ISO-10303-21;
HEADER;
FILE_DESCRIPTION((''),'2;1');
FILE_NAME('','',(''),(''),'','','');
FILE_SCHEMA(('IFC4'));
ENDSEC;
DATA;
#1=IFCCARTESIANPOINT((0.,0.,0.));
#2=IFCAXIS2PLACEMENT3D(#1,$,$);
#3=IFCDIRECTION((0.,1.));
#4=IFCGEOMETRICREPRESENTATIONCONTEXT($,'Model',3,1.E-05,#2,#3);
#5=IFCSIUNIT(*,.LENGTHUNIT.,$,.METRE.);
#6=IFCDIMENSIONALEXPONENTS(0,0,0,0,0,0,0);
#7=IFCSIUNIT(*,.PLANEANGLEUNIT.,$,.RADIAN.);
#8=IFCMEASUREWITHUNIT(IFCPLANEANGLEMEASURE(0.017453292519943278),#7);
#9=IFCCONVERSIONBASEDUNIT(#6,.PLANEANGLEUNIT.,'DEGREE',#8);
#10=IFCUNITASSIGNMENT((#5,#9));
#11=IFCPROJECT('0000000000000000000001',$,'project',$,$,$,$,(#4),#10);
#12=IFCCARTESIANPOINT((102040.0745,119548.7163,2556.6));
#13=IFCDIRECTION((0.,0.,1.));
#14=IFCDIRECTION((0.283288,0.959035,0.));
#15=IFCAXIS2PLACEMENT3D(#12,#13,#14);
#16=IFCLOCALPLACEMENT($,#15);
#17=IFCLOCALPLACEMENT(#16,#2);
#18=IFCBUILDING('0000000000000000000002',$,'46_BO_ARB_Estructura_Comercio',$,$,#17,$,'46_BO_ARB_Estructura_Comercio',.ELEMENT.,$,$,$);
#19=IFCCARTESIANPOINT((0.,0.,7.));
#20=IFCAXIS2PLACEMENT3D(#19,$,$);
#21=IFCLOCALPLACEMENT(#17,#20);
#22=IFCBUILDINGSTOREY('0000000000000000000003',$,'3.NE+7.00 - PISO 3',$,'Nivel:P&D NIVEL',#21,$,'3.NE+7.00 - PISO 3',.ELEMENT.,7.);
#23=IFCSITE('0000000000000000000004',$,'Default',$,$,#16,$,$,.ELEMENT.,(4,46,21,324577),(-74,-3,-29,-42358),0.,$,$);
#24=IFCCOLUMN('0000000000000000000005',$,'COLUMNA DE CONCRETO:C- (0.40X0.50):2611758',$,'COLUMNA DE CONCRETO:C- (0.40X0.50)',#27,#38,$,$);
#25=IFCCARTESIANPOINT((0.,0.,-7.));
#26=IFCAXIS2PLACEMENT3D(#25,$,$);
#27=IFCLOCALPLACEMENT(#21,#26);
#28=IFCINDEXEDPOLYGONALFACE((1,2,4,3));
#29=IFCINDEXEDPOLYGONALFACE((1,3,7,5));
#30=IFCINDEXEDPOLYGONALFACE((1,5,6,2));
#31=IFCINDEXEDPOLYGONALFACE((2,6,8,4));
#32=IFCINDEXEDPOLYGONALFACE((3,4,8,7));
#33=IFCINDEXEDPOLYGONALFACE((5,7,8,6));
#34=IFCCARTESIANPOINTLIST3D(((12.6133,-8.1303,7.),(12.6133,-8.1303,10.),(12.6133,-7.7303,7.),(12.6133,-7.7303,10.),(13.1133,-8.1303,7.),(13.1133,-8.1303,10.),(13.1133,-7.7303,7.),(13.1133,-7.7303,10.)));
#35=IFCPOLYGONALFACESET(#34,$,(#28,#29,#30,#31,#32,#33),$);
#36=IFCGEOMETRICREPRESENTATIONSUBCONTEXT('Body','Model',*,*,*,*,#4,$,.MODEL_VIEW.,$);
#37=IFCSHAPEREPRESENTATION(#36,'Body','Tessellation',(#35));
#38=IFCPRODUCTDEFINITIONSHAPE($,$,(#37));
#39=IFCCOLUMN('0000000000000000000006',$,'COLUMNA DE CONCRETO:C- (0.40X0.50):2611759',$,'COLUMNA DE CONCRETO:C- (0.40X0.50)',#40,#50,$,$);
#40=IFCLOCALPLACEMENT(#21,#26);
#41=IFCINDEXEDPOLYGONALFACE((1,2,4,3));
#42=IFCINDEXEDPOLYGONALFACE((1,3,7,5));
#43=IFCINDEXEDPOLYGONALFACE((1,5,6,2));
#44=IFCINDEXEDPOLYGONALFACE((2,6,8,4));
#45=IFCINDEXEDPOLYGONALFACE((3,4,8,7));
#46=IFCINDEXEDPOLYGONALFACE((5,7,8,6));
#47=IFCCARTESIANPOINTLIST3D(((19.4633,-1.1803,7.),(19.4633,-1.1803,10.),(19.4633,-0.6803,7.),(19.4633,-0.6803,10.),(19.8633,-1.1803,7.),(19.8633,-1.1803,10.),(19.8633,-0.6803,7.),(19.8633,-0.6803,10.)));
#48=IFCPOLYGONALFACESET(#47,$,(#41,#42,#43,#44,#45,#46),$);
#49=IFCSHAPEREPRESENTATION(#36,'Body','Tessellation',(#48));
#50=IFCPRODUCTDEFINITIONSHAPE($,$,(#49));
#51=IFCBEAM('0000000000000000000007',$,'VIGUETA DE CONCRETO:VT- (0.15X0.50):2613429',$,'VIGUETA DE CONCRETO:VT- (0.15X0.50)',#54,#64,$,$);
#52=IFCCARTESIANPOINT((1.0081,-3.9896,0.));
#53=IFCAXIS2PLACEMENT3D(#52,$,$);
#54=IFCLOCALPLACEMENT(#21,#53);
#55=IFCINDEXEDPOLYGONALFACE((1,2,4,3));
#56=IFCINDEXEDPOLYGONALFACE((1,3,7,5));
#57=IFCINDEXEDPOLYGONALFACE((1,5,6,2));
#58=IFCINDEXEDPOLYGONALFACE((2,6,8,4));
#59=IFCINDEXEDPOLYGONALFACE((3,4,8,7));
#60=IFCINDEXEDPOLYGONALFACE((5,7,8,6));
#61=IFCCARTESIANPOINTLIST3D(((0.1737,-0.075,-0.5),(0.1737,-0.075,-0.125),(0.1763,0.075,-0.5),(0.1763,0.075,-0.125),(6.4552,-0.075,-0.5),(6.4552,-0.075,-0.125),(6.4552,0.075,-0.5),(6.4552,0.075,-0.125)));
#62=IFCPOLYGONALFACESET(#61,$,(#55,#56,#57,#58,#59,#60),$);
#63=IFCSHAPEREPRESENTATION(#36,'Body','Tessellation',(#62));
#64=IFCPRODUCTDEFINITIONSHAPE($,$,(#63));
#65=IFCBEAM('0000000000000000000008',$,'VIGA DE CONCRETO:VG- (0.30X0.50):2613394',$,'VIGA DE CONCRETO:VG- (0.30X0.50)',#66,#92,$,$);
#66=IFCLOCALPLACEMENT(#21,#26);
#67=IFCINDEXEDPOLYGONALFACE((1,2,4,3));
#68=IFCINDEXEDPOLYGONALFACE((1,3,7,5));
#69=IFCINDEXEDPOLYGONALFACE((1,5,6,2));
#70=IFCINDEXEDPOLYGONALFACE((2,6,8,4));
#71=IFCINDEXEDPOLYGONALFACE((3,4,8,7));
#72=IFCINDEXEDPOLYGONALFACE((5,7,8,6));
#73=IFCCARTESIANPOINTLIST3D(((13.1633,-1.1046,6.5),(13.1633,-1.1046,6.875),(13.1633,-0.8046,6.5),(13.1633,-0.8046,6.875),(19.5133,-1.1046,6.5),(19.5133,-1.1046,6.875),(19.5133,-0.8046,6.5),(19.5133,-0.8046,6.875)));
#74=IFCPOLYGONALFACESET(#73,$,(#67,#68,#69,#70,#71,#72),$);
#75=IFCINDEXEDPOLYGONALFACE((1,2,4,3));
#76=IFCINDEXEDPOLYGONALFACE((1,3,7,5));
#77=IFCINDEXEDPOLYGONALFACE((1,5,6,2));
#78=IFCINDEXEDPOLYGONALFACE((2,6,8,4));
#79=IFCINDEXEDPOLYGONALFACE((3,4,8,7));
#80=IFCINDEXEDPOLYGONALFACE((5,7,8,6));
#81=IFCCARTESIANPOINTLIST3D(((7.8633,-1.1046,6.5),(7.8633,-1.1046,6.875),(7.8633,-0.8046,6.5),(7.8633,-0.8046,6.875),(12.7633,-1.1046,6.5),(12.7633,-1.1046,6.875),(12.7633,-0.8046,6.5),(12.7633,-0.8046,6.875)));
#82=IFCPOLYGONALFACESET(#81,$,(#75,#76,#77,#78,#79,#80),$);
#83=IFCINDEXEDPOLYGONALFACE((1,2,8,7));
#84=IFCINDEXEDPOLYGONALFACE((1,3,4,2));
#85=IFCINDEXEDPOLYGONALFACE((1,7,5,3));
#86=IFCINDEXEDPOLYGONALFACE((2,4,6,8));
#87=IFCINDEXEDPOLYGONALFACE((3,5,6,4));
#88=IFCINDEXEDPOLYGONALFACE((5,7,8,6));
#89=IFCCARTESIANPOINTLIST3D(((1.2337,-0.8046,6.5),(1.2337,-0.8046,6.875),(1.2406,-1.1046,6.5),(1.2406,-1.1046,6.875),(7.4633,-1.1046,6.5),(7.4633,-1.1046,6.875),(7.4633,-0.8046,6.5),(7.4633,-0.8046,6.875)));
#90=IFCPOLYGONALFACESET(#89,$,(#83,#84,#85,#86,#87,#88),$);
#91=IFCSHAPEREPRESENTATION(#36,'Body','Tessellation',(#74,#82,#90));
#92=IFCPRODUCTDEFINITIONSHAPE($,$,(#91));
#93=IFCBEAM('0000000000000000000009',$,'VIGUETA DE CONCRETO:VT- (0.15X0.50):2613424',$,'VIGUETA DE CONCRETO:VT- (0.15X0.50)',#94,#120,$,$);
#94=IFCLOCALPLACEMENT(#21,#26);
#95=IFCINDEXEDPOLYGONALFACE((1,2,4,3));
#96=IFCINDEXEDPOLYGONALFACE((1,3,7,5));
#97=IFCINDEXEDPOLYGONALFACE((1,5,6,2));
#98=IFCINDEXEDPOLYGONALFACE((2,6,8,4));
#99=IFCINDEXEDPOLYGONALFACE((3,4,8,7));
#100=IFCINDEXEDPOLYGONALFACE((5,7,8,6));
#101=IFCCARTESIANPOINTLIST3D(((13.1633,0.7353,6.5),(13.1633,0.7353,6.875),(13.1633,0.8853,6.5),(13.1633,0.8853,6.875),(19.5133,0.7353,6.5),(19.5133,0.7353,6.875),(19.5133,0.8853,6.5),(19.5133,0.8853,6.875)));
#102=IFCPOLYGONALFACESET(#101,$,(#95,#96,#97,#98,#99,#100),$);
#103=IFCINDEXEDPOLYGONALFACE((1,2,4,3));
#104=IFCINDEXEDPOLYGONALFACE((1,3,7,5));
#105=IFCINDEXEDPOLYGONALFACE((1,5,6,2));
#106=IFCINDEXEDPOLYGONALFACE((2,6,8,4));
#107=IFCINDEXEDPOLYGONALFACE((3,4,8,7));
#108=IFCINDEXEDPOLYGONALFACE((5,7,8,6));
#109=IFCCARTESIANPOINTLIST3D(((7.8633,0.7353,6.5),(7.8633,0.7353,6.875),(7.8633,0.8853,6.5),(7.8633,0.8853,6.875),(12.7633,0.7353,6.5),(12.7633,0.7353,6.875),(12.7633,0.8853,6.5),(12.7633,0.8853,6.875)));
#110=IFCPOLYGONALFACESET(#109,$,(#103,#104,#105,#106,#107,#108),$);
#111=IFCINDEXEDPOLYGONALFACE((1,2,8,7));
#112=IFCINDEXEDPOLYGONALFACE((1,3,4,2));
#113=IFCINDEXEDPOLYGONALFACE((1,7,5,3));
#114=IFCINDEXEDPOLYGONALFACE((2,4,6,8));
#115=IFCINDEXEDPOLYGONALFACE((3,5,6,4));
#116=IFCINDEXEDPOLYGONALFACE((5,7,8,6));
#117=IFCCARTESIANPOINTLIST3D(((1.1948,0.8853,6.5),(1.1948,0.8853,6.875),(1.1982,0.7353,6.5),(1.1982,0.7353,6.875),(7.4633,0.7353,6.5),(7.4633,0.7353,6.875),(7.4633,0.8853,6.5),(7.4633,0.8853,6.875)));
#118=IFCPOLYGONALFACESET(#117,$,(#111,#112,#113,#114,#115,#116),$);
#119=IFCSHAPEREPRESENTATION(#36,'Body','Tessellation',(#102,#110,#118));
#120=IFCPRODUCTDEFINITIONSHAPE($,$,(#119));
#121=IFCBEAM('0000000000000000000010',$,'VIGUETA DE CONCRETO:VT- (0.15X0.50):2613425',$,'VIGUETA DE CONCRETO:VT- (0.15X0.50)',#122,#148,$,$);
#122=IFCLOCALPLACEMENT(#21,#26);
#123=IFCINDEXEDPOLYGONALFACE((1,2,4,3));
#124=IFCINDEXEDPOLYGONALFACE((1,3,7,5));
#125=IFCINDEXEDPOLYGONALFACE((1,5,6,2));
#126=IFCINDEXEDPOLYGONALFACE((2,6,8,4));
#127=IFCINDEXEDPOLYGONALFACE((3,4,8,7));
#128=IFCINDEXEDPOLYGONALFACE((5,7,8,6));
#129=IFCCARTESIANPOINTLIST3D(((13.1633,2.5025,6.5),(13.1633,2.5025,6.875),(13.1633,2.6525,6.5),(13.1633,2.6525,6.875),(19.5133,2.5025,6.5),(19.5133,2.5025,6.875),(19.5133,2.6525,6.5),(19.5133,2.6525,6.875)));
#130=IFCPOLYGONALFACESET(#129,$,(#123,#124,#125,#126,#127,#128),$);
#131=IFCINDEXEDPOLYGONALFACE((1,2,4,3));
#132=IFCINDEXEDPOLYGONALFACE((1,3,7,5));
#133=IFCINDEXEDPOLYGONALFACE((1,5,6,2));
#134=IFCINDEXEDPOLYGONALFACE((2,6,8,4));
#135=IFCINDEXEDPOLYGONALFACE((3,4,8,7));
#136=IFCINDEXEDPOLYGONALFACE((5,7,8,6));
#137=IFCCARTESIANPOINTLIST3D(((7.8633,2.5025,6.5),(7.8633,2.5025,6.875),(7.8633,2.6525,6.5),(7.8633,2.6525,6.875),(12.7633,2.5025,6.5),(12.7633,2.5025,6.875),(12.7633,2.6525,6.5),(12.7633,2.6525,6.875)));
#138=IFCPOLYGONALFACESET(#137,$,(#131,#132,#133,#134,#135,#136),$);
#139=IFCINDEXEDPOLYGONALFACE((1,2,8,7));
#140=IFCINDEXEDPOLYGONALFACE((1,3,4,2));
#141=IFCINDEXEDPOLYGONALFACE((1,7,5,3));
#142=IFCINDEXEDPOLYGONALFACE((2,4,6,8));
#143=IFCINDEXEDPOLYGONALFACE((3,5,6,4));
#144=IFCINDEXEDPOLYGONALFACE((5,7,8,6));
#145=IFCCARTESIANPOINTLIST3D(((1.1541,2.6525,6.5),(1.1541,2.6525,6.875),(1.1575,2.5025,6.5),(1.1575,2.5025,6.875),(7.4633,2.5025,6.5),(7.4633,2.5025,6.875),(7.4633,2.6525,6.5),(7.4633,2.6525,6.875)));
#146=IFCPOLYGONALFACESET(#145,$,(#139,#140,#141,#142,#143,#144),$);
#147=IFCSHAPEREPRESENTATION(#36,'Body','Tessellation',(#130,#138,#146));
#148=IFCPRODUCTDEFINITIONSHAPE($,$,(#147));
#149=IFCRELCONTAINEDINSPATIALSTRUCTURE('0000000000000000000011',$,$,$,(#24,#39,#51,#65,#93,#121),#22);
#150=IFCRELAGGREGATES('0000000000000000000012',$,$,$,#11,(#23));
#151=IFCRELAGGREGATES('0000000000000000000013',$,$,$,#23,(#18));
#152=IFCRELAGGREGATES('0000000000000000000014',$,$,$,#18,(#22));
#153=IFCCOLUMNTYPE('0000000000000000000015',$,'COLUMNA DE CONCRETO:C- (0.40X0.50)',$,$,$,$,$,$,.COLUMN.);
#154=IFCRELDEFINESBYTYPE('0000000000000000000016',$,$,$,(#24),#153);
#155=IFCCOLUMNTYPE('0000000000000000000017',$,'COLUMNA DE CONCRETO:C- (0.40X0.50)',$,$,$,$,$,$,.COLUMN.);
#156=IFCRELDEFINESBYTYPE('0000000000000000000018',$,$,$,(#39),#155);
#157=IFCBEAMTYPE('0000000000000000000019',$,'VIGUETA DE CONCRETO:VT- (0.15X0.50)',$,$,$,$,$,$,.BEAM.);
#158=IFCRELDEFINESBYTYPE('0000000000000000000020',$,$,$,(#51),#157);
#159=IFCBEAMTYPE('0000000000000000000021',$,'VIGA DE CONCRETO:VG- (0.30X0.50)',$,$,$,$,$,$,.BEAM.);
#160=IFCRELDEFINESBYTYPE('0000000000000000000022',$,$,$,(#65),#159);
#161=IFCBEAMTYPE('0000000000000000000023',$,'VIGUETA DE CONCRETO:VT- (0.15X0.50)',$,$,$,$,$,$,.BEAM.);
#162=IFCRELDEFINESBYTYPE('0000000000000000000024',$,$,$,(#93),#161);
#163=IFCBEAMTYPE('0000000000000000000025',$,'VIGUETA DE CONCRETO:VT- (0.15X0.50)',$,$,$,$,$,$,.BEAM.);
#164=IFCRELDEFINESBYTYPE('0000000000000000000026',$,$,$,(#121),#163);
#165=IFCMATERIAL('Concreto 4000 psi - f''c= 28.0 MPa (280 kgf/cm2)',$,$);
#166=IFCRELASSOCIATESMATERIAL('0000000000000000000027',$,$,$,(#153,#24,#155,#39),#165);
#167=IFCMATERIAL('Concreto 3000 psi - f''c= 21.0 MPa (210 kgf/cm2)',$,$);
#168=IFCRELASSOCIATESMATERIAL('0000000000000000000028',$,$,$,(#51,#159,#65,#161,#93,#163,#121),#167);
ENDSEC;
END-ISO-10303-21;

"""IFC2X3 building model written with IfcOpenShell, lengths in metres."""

from ifc_helpers import new_model, entity, si_unit, converted_unit, direction, frame, frame_2d, origin, place, context, subcontext, project, spatial, rectangle, extrude, clip, halfspace, source, transform, mapped, material, type_object, type_shapes, element, save


model = new_model("IFC2X3")

# Units and contexts
model_context = context("Model", 3, precision=1e-05, world=origin(), true_north=direction((0.0, 1.0)))
body_context = subcontext(model_context, "Body", "Model", "MODEL_VIEW")
ifc_project = project(units=[si_unit("LENGTHUNIT", "METRE"), converted_unit("PLANEANGLEUNIT", "DEGREE", entity("IfcPlaneAngleMeasure", 0.017453292519943278), si_unit("PLANEANGLEUNIT", "RADIAN"), dimensions=[0, 0, 0, 0, 0, 0, 0])], contexts=[model_context])

# Site, building, storey
site_placement = place(None, frame((102040.0745, 119548.7163, 2556.6), z_axis=(0.0, 0.0, 1.0), x_axis=(0.283288, 0.959035, 0.0)))
site = spatial("IfcSite", under=ifc_project, at=site_placement, Name="Default", CompositionType="ELEMENT", RefLatitude=(4, 46, 21, 324577), RefLongitude=(-74, -3, -29, -42358), RefElevation=0.0)
building_placement = place(site_placement, origin())
building = spatial("IfcBuilding", under=site, at=building_placement, Name="46_BO_ARB_Estructura_Comercio", LongName="46_BO_ARB_Estructura_Comercio", CompositionType="ELEMENT")
storey_placement = place(building_placement, frame((0.0, 0.0, 7.0)))
storey = spatial("IfcBuildingStorey", under=building, at=storey_placement, Name="3.NE+7.00 - PISO 3", ObjectType="Nivel:P&D NIVEL", LongName="3.NE+7.00 - PISO 3", CompositionType="ELEMENT", Elevation=7.0)

# Columns
ifc_material_1 = material(Name="Concreto 4000 psi - f'c= 28.0 MPa (280 kgf/cm2)")
column_type_1 = type_object("IfcColumnType", Name="COLUMNA DE CONCRETO:C- (0.40X0.50)", PredefinedType="COLUMN", material=ifc_material_1)
shared_shape_1 = source(origin(), body_context, "Body", "SweptSolid", [
    extrude(rectangle(XDim=0.4, YDim=0.5, at=frame_2d((0.0, 0.0), x_axis=(1.0, 0.0))), frame((12.8633, -7.9303, 7.0), z_axis=(0.0, 0.0, 1.0), x_axis=(0.0, -1.0, 0.0)), (0.0, 0.0, 1.0), 3.0),
])
type_shapes(column_type_1, [shared_shape_1])
column_1_placement = place(storey_placement, frame((0.0, 0.0, -7.0)))
element("IfcColumn", 1, at=column_1_placement, inside=storey, type_object=column_type_1, material=ifc_material_1, Name="COLUMNA DE CONCRETO:C- (0.40X0.50):2611758", ObjectType="COLUMNA DE CONCRETO:C- (0.40X0.50)", context=body_context, shape_type="MappedRepresentation", body=[
    mapped(shared_shape_1, transform((0.0, 0.0, 0.0), scale=1.0)),
])
column_type_2 = type_object("IfcColumnType", Name="COLUMNA DE CONCRETO:C- (0.40X0.50)", PredefinedType="COLUMN", material=ifc_material_1)
shared_shape_2 = source(origin(), body_context, "Body", "SweptSolid", [
    extrude(rectangle(XDim=0.5, YDim=0.4, at=frame_2d((0.0, 0.0), x_axis=(1.0, 0.0))), frame((19.6633, -0.9303, 7.0), z_axis=(0.0, 0.0, 1.0), x_axis=(0.0, -1.0, 0.0)), (0.0, 0.0, 1.0), 3.0),
])
type_shapes(column_type_2, [shared_shape_2])
column_2_placement = place(storey_placement, frame((0.0, 0.0, -7.0)))
element("IfcColumn", 2, at=column_2_placement, inside=storey, type_object=column_type_2, material=ifc_material_1, Name="COLUMNA DE CONCRETO:C- (0.40X0.50):2611759", ObjectType="COLUMNA DE CONCRETO:C- (0.40X0.50)", context=body_context, shape_type="MappedRepresentation", body=[
    mapped(shared_shape_2, transform((0.0, 0.0, 0.0), scale=1.0)),
])

# Beams
ifc_material_2 = material(Name="Concreto 3000 psi - f'c= 21.0 MPa (210 kgf/cm2)")
beam_type_1 = type_object("IfcBeamType", Name="VIGUETA DE CONCRETO:VT- (0.15X0.50)", PredefinedType="BEAM")
beam_1_placement = place(storey_placement, frame((1.0081, -3.9896, 0.0)))
element("IfcBeam", 3, at=beam_1_placement, inside=storey, type_object=beam_type_1, material=ifc_material_2, Name="VIGUETA DE CONCRETO:VT- (0.15X0.50):2613429", ObjectType="VIGUETA DE CONCRETO:VT- (0.15X0.50)", context=body_context, shape_type="SweptSolid", body=[
    clip(extrude(rectangle(XDim=0.375, YDim=0.15, at=frame_2d((0.0, 0.0), x_axis=(1.0, 0.0))), frame((0.1737, 0.0, -0.3125), z_axis=(1.0, 0.0, 0.0), x_axis=(0.0, 0.0, -1.0)), (0.0, 0.0, 1.0), 6.2815), halfspace(frame((0.2277, 3.0122, 0.0), z_axis=(-0.999847, 0.017477, 0.0), x_axis=(-0.017477, -0.999847, 0.0)), False)),
])
beam_type_2 = type_object("IfcBeamType", Name="VIGA DE CONCRETO:VG- (0.30X0.50)", PredefinedType="BEAM", material=ifc_material_2)
shared_shape_3 = source(origin(), body_context, "Body", "SweptSolid", [
    extrude(rectangle(XDim=0.375, YDim=0.3, at=frame_2d((0.0, 0.0), x_axis=(1.0, 0.0))), frame((13.1633, -0.9546, 6.6875), z_axis=(1.0, 0.0, 0.0), x_axis=(0.0, 0.0, -1.0)), (0.0, 0.0, 1.0), 6.35),
    extrude(rectangle(XDim=0.375, YDim=0.3, at=frame_2d((0.0, 0.0), x_axis=(1.0, 0.0))), frame((7.8633, -0.9546, 6.6875), z_axis=(1.0, 0.0, 0.0), x_axis=(0.0, 0.0, -1.0)), (0.0, 0.0, 1.0), 4.9),
    clip(extrude(rectangle(XDim=0.375, YDim=0.3, at=frame_2d((0.0, 0.0), x_axis=(1.0, 0.0))), frame((1.2337, -0.9546, 6.6875), z_axis=(1.0, 0.0, 0.0), x_axis=(0.0, 0.0, -1.0)), (0.0, 0.0, 1.0), 6.2296), halfspace(frame((1.1171, 4.257, 7.0), z_axis=(-0.999735, -0.023028, 0.0), x_axis=(0.023028, -0.999735, 0.0)), False)),
])
type_shapes(beam_type_2, [shared_shape_3])
beam_2_placement = place(storey_placement, frame((0.0, 0.0, -7.0)))
element("IfcBeam", 4, at=beam_2_placement, inside=storey, type_object=beam_type_2, material=ifc_material_2, Name="VIGA DE CONCRETO:VG- (0.30X0.50):2613394", ObjectType="VIGA DE CONCRETO:VG- (0.30X0.50)", context=body_context, shape_type="MappedRepresentation", body=[
    mapped(shared_shape_3, transform((0.0, 0.0, 0.0), scale=1.0)),
])
beam_type_3 = type_object("IfcBeamType", Name="VIGUETA DE CONCRETO:VT- (0.15X0.50)", PredefinedType="BEAM", material=ifc_material_2)
shared_shape_4 = source(origin(), body_context, "Body", "SweptSolid", [
    extrude(rectangle(XDim=0.375, YDim=0.15, at=frame_2d((0.0, 0.0), x_axis=(1.0, 0.0))), frame((13.1633, 0.8103, 6.6875), z_axis=(1.0, 0.0, 0.0), x_axis=(0.0, 0.0, -1.0)), (0.0, 0.0, 1.0), 6.35),
    extrude(rectangle(XDim=0.375, YDim=0.15, at=frame_2d((0.0, 0.0), x_axis=(1.0, 0.0))), frame((7.8633, 0.8103, 6.6875), z_axis=(1.0, 0.0, 0.0), x_axis=(0.0, 0.0, -1.0)), (0.0, 0.0, 1.0), 4.9),
    clip(extrude(rectangle(XDim=0.375, YDim=0.15, at=frame_2d((0.0, 0.0), x_axis=(1.0, 0.0))), frame((1.1948, 0.8103, 6.6875), z_axis=(1.0, 0.0, 0.0), x_axis=(0.0, 0.0, -1.0)), (0.0, 0.0, 1.0), 6.2685), halfspace(frame((1.1171, 4.257, 7.0), z_axis=(-0.999735, -0.023028, 0.0), x_axis=(0.023028, -0.999735, 0.0)), False)),
])
type_shapes(beam_type_3, [shared_shape_4])
beam_3_placement = place(storey_placement, frame((0.0, 0.0, -7.0)))
element("IfcBeam", 5, at=beam_3_placement, inside=storey, type_object=beam_type_3, material=ifc_material_2, Name="VIGUETA DE CONCRETO:VT- (0.15X0.50):2613424", ObjectType="VIGUETA DE CONCRETO:VT- (0.15X0.50)", context=body_context, shape_type="MappedRepresentation", body=[
    mapped(shared_shape_4, transform((0.0, 0.0, 0.0), scale=1.0)),
])
beam_type_4 = type_object("IfcBeamType", Name="VIGUETA DE CONCRETO:VT- (0.15X0.50)", PredefinedType="BEAM", material=ifc_material_2)
shared_shape_5 = source(origin(), body_context, "Body", "SweptSolid", [
    extrude(rectangle(XDim=0.375, YDim=0.15, at=frame_2d((0.0, 0.0), x_axis=(1.0, 0.0))), frame((13.1633, 2.5775, 6.6875), z_axis=(1.0, 0.0, 0.0), x_axis=(0.0, 0.0, -1.0)), (0.0, 0.0, 1.0), 6.35),
    extrude(rectangle(XDim=0.375, YDim=0.15, at=frame_2d((0.0, 0.0), x_axis=(1.0, 0.0))), frame((7.8633, 2.5775, 6.6875), z_axis=(1.0, 0.0, 0.0), x_axis=(0.0, 0.0, -1.0)), (0.0, 0.0, 1.0), 4.9),
    clip(extrude(rectangle(XDim=0.375, YDim=0.15, at=frame_2d((0.0, 0.0), x_axis=(1.0, 0.0))), frame((1.1541, 2.5775, 6.6875), z_axis=(1.0, 0.0, 0.0), x_axis=(0.0, 0.0, -1.0)), (0.0, 0.0, 1.0), 6.3092), halfspace(frame((1.1171, 4.257, 7.0), z_axis=(-0.999735, -0.023028, 0.0), x_axis=(0.023028, -0.999735, 0.0)), False)),
])
type_shapes(beam_type_4, [shared_shape_5])
beam_4_placement = place(storey_placement, frame((0.0, 0.0, -7.0)))
element("IfcBeam", 6, at=beam_4_placement, inside=storey, type_object=beam_type_4, material=ifc_material_2, Name="VIGUETA DE CONCRETO:VT- (0.15X0.50):2613425", ObjectType="VIGUETA DE CONCRETO:VT- (0.15X0.50)", context=body_context, shape_type="MappedRepresentation", body=[
    mapped(shared_shape_5, transform((0.0, 0.0, 0.0), scale=1.0)),
])

save(model, "model.ifc")
